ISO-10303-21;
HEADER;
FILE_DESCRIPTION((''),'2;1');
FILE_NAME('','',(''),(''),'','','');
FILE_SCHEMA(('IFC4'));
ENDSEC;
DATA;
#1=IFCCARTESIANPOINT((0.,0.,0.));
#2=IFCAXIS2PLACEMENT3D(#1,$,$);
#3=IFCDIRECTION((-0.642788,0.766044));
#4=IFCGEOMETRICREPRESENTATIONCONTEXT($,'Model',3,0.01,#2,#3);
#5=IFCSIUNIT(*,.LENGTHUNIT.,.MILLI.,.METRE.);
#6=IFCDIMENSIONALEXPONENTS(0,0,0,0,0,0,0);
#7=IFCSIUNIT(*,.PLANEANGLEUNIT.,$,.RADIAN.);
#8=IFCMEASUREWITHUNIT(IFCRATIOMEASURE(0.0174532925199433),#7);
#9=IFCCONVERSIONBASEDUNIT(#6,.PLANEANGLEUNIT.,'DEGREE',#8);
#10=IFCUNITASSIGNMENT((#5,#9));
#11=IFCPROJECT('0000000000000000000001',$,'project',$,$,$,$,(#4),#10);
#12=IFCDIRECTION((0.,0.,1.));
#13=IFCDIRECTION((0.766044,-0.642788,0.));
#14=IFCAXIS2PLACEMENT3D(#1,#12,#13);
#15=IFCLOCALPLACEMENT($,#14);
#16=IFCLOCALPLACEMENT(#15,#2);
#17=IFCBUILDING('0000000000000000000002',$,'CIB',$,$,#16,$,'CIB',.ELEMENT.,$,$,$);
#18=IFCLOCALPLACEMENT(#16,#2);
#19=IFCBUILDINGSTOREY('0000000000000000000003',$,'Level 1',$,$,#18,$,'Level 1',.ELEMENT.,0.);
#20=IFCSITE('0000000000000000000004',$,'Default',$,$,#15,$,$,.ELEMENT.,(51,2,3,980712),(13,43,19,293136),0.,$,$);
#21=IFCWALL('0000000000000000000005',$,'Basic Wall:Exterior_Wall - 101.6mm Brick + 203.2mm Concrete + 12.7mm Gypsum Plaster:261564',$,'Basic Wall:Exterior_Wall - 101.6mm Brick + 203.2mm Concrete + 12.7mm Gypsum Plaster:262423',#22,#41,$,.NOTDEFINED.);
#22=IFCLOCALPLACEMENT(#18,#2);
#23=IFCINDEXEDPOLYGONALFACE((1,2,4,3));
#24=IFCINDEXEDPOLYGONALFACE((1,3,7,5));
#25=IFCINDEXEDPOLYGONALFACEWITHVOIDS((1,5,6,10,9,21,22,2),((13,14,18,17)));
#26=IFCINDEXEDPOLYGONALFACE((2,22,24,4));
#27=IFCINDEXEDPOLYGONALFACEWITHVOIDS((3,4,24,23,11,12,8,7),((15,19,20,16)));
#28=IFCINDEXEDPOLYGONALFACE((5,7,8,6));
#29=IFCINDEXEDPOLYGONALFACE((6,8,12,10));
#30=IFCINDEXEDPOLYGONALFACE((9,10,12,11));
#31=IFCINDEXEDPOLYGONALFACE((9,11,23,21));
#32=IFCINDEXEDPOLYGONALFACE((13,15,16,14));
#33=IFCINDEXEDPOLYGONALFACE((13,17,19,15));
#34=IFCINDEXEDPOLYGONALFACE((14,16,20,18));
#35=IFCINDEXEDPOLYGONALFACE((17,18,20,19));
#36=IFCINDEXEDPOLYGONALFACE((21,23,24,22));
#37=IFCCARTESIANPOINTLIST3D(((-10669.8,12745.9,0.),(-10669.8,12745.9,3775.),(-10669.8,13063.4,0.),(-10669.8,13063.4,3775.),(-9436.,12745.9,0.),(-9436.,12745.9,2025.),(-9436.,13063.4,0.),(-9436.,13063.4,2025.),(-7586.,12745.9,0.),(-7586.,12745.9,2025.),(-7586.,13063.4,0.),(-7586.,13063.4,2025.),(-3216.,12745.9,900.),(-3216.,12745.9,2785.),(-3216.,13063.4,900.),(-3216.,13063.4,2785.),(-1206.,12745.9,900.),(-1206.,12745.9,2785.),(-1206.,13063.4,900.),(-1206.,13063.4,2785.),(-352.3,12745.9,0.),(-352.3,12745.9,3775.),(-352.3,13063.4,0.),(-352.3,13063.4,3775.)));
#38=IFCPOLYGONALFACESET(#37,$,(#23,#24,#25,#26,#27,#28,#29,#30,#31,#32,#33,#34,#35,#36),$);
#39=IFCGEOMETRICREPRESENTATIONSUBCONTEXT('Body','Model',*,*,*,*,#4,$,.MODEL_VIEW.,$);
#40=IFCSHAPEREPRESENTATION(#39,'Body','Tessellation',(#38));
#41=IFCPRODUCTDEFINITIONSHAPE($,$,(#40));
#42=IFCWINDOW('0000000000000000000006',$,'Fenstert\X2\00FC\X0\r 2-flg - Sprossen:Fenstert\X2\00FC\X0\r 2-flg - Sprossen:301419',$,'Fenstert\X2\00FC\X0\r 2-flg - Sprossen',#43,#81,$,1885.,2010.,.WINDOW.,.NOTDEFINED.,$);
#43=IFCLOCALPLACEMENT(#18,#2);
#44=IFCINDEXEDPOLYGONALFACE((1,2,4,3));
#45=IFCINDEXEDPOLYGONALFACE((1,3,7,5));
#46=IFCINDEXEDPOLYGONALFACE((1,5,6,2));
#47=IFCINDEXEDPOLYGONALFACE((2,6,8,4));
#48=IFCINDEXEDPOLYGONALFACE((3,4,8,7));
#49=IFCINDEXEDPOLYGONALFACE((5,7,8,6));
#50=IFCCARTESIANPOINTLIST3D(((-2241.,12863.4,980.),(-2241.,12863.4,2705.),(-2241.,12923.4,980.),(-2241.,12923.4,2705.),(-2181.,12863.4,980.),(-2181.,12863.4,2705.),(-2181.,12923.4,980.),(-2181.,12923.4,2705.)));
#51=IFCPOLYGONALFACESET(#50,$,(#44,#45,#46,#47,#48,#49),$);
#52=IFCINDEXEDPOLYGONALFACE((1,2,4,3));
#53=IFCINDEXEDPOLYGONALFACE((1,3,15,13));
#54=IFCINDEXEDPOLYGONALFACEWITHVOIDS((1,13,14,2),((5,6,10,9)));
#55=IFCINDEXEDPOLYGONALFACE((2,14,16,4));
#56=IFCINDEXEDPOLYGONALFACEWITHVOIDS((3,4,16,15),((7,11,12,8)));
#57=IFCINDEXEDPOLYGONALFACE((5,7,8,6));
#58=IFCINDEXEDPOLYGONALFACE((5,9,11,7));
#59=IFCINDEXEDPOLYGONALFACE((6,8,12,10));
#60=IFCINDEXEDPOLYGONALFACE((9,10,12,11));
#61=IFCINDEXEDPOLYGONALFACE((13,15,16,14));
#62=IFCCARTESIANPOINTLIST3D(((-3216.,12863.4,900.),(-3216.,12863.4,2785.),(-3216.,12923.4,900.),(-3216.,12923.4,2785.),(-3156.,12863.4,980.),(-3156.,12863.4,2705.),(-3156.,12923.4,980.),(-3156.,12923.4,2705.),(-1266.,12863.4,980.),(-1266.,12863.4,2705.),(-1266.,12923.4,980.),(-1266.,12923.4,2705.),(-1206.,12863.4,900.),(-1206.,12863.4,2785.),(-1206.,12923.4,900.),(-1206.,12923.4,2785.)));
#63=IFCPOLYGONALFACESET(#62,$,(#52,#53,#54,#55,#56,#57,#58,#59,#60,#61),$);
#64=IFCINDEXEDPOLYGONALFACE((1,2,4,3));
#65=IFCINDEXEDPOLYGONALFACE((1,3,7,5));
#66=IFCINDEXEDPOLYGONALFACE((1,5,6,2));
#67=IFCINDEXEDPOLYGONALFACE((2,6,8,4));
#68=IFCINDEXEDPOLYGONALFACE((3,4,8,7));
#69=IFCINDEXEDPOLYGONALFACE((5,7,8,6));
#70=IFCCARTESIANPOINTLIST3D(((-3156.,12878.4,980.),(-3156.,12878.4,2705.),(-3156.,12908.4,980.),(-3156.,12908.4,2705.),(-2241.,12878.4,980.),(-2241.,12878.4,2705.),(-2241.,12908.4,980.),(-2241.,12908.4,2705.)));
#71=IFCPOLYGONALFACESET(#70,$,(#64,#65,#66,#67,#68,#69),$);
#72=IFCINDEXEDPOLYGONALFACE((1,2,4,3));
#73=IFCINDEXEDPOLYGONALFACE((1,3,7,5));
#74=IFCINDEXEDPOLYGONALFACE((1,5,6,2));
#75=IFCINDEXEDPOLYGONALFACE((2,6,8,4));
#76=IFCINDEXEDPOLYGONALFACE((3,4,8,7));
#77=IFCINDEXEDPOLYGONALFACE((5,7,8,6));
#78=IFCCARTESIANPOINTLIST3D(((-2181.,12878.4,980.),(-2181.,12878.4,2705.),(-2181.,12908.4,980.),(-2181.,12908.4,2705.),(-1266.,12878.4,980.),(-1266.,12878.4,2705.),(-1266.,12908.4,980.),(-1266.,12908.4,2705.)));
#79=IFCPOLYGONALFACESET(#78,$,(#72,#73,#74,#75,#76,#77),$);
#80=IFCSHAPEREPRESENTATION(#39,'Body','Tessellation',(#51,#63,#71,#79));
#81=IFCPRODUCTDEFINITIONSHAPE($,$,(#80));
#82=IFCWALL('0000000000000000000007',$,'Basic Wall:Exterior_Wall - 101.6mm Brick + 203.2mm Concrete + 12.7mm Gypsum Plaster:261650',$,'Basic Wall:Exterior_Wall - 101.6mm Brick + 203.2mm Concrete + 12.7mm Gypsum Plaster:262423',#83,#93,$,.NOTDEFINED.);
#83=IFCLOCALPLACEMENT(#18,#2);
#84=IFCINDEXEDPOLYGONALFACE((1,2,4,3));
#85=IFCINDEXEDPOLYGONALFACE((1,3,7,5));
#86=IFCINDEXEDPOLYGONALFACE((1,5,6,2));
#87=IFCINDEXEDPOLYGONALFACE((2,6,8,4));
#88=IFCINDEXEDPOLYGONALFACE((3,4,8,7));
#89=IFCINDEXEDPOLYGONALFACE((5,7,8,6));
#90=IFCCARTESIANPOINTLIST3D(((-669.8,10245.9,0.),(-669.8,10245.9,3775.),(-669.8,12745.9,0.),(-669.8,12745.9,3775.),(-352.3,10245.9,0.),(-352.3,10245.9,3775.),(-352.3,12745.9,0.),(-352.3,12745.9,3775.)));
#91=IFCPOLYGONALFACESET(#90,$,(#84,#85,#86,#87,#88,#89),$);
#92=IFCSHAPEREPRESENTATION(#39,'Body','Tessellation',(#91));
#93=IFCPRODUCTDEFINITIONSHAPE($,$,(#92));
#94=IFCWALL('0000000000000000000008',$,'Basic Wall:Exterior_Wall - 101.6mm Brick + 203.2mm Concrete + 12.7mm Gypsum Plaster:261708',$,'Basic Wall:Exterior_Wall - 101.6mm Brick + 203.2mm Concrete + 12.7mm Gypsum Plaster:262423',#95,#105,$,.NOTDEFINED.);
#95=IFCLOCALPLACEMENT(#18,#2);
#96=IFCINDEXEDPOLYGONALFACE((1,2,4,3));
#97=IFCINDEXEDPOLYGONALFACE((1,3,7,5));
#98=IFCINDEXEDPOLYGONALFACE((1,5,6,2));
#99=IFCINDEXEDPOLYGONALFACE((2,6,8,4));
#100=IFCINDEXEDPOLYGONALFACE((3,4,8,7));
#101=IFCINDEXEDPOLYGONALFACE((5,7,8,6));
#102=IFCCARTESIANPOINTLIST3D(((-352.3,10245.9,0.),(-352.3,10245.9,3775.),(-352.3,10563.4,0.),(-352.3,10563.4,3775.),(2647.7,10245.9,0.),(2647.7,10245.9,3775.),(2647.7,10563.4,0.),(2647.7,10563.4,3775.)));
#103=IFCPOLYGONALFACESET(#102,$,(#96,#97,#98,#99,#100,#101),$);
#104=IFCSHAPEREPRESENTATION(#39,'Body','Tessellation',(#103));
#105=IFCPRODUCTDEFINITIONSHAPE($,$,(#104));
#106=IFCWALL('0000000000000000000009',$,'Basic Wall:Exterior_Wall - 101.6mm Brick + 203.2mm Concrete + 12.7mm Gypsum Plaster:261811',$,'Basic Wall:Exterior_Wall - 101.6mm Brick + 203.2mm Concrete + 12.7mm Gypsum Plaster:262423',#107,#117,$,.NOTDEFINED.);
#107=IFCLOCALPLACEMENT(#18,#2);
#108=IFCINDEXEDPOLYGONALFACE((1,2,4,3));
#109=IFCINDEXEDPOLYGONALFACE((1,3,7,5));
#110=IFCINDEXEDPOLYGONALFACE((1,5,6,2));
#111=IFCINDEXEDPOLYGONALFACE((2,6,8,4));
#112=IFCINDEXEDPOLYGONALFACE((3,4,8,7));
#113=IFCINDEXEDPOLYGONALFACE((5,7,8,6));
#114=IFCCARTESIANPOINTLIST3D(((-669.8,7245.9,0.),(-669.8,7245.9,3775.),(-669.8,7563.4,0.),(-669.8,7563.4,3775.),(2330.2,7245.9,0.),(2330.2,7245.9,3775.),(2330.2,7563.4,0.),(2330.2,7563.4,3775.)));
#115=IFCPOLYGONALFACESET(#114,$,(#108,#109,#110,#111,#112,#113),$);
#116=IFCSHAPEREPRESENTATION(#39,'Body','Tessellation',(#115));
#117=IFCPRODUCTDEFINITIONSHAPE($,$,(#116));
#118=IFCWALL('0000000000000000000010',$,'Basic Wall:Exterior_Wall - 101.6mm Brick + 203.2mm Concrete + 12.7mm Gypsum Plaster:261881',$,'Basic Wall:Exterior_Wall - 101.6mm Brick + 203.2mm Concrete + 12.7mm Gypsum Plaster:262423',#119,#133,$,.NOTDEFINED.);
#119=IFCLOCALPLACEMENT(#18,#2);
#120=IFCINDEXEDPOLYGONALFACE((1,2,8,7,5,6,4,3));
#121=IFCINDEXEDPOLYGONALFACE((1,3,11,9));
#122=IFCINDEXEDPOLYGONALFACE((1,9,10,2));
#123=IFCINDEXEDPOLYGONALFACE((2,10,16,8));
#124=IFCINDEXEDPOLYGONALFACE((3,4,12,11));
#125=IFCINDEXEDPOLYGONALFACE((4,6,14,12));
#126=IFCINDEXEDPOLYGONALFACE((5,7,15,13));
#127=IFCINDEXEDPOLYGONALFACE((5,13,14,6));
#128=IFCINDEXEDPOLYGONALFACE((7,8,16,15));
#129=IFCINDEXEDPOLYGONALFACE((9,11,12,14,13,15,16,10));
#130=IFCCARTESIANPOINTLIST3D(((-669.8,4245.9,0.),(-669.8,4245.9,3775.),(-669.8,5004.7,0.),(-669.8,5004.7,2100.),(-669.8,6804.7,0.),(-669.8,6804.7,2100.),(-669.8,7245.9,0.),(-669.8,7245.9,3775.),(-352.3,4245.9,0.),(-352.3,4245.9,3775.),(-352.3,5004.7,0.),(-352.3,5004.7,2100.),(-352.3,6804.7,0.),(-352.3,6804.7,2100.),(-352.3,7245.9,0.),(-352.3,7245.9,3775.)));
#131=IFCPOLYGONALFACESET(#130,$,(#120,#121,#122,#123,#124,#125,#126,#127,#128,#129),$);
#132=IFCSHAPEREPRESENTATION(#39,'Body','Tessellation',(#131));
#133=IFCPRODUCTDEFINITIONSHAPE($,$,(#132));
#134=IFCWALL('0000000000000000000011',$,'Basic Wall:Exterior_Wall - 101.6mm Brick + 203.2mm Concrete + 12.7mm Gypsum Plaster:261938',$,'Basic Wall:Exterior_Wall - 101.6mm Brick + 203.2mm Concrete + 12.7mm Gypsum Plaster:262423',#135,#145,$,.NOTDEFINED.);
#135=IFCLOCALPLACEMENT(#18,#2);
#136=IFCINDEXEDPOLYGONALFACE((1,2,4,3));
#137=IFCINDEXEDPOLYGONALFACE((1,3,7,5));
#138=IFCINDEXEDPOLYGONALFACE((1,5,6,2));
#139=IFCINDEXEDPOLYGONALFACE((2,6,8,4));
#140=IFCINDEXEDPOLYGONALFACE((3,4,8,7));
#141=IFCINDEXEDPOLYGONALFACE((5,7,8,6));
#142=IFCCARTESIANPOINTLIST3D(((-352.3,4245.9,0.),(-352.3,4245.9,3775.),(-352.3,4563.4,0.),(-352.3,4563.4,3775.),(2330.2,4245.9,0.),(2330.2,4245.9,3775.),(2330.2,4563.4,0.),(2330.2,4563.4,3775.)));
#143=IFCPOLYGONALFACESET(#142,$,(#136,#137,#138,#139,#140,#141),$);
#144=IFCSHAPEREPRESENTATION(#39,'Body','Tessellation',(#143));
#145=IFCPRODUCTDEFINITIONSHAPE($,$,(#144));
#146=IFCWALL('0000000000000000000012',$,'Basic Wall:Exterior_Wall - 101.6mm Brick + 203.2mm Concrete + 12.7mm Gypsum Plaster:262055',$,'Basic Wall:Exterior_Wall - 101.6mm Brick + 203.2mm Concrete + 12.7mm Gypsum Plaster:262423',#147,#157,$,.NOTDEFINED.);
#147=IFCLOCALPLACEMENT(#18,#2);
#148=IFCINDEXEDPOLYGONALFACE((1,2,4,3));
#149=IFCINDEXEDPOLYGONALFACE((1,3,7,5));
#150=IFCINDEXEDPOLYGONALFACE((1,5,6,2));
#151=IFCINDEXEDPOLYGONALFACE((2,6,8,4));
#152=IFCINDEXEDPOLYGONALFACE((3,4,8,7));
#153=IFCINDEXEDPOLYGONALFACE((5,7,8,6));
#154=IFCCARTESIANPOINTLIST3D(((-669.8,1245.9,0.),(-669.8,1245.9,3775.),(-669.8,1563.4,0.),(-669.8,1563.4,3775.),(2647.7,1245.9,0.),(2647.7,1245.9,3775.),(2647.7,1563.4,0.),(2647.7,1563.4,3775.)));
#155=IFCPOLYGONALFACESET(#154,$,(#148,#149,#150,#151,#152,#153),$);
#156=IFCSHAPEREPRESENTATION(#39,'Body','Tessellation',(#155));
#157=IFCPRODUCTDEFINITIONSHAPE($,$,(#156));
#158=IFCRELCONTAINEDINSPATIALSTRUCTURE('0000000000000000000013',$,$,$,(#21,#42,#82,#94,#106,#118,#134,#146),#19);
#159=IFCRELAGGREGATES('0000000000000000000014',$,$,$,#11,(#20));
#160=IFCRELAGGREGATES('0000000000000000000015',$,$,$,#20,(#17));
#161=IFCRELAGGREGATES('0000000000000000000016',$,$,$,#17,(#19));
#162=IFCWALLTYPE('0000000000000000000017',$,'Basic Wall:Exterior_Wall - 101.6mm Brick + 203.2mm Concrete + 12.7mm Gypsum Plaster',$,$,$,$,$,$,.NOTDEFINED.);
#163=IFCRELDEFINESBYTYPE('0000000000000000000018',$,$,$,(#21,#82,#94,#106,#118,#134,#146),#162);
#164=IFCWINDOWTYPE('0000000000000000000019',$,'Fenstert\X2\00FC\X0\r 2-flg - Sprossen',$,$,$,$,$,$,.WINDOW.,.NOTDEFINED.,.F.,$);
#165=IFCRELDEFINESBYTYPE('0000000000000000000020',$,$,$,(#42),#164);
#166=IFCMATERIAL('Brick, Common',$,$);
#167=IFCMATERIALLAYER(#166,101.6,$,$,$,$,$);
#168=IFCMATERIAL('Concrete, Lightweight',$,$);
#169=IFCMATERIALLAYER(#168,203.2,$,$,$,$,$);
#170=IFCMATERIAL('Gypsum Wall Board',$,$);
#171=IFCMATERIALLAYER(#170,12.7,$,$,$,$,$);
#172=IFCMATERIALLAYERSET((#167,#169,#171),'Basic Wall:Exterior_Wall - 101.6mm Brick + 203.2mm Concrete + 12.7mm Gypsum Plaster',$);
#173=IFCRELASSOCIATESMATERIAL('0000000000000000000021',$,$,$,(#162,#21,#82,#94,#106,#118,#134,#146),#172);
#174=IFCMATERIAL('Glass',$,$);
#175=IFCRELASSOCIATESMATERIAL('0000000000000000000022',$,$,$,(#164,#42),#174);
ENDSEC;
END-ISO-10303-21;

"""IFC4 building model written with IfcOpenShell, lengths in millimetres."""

from ifc_helpers import new_model, entity, si_unit, converted_unit, direction, frame, frame_2d, origin, origin_2d_with_axis, place, context, subcontext, project, spatial, polyline, rectangle, outline, extrude, clip, bounded_halfspace, source, transform, mapped, material, layer, layer_set, layer_usage, type_object, type_shapes, element, fill, save


model = new_model("IFC4")

# Units and contexts
model_context = context("Model", 3, precision=0.01, world=origin(), true_north=direction((-0.642788, 0.766044)))
body_context = subcontext(model_context, "Body", "Model", "MODEL_VIEW")
ifc_project = project(units=[si_unit("LENGTHUNIT", "METRE", prefix="MILLI"), converted_unit("PLANEANGLEUNIT", "DEGREE", entity("IfcRatioMeasure", 0.0174532925199433), si_unit("PLANEANGLEUNIT", "RADIAN"), dimensions=[0, 0, 0, 0, 0, 0, 0])], contexts=[model_context])

# Site, building, storey
site_placement = place(None, frame((0.0, 0.0, 0.0), z_axis=(0.0, 0.0, 1.0), x_axis=(0.766044, -0.642788, 0.0)))
site = spatial("IfcSite", under=ifc_project, at=site_placement, Name="Default", CompositionType="ELEMENT", RefLatitude=(51, 2, 3, 980712), RefLongitude=(13, 43, 19, 293136), RefElevation=0.0)
building_placement = place(site_placement, origin())
building = spatial("IfcBuilding", under=site, at=building_placement, Name="CIB", LongName="CIB", CompositionType="ELEMENT")
storey_placement = place(building_placement, origin())
storey = spatial("IfcBuildingStorey", under=building, at=storey_placement, Name="Level 1", LongName="Level 1", CompositionType="ELEMENT", Elevation=0.0)

# Wall, openings, window
ifc_material_1 = material(Name="Brick, Common")
ifc_layer_1 = layer(ifc_material_1, 101.6)
ifc_material_2 = material(Name="Concrete, Lightweight")
ifc_layer_2 = layer(ifc_material_2, 203.2)
ifc_material_3 = material(Name="Gypsum Wall Board")
ifc_layer_3 = layer(ifc_material_3, 12.7)
ifc_layer_set_1 = layer_set([ifc_layer_1, ifc_layer_2, ifc_layer_3], Name="Basic Wall:Exterior_Wall - 101.6mm Brick + 203.2mm Concrete + 12.7mm Gypsum Plaster")
ifc_layer_usage_1 = layer_usage(ifc_layer_set_1, "AXIS2", "NEGATIVE", 158.8)
wall_type_1 = type_object("IfcWallType", Name="Basic Wall:Exterior_Wall - 101.6mm Brick + 203.2mm Concrete + 12.7mm Gypsum Plaster", PredefinedType="NOTDEFINED", material=ifc_layer_set_1)
wall_1_placement = place(storey_placement, frame((-10669.8, 12904.7, 0.0)))
wall_1 = element("IfcWall", 1, at=wall_1_placement, inside=storey, type_object=wall_type_1, material=ifc_layer_usage_1, Name="Basic Wall:Exterior_Wall - 101.6mm Brick + 203.2mm Concrete + 12.7mm Gypsum Plaster:261564", ObjectType="Basic Wall:Exterior_Wall - 101.6mm Brick + 203.2mm Concrete + 12.7mm Gypsum Plaster:262423", PredefinedType="NOTDEFINED", context=body_context, shape_type="Clipping", body=[
    clip(extrude(rectangle(XDim=10317.5, YDim=317.5, at=frame_2d((5158.7, 0.0), x_axis=(-1.0, 0.0))), origin(), (0.0, 0.0, 1.0), 3775.0), bounded_halfspace(frame((0.0, -158.7, 3775.0), z_axis=(0.0, 0.0, -1.0), x_axis=(1.0, 0.0, 0.0)), True, frame((0.0, -158.7, 3775.0)), polyline([(0.0, 0.0), (317.5, 0.0), (10000.0, 0.0), (10317.5, 0.0), (10317.5, 317.5), (0.0, 317.5), (0.0, 0.0)]))),
])
opening_1_placement = place(wall_1_placement, frame((3083.8, 158.7, 0.0)))
element("IfcOpeningElement", 2, at=opening_1_placement, cuts=wall_1, ObjectType="Opening", PredefinedType="OPENING", context=body_context, shape_type="SweptSolid", body=[
    extrude(rectangle(XDim=2025.0, YDim=1850.0, at=frame_2d((1012.5, 925.0), x_axis=(1.0, 0.0))), frame((0.0, 0.0, 0.0), z_axis=(0.0, -1.0, 0.0), x_axis=(0.0, 0.0, 1.0)), (0.0, 0.0, 1.0), 317.5),
])
opening_2_placement = place(wall_1_placement, frame((9463.7, 158.7, 900.0)))
opening_2 = element("IfcOpeningElement", 3, at=opening_2_placement, cuts=wall_1, ObjectType="Opening", PredefinedType="OPENING", context=body_context, shape_type="SweptSolid", body=[
    extrude(rectangle(XDim=1885.0, YDim=2010.0, at=frame_2d((942.5, 1005.0), x_axis=(1.0, 0.0))), frame((0.0, 0.0, 0.0), z_axis=(0.0, -1.0, 0.0), x_axis=(0.0, 0.0, 1.0)), (0.0, 0.0, 1.0), 317.5),
])
ifc_material_4 = material(Name="Glass")
window_type_1 = type_object("IfcWindowType", Name="Fenstertür 2-flg - Sprossen", ParameterTakesPrecedence=False, PartitioningType="NOTDEFINED", PredefinedType="WINDOW", material=ifc_material_4)
shared_shape_1 = source(origin(), body_context, "Body", "SweptSolid", [
    extrude(rectangle(XDim=60.0, YDim=60.0, at=origin_2d_with_axis()), frame((1005.0, 147.5, 80.0), z_axis=(0.0, 0.0, 1.0), x_axis=(0.0, 1.0, 0.0)), (0.0, 0.0, 1.0), 1725.0),
    extrude(outline(polyline([(-1005.0, -942.5), (1005.0, -942.5), (1005.0, 942.5), (-1005.0, 942.5), (-1005.0, -942.5)]), holes=[polyline([(-945.0, -862.5), (-945.0, 862.5), (945.0, 862.5), (945.0, -862.5), (-945.0, -862.5)])]), frame((1005.0, 117.5, 942.5), z_axis=(0.0, 1.0, 0.0), x_axis=(1.0, 0.0, 0.0)), (0.0, 0.0, 1.0), 60.0),
    extrude(rectangle(XDim=30.0, YDim=915.0, at=frame_2d((0.0, 0.0), x_axis=(1.0, 0.0))), frame((517.5, 147.5, 80.0), z_axis=(0.0, 0.0, 1.0), x_axis=(0.0, -1.0, 0.0)), (0.0, 0.0, 1.0), 1725.0),
    extrude(rectangle(XDim=30.0, YDim=915.0, at=frame_2d((0.0, 0.0), x_axis=(1.0, 0.0))), frame((1492.5, 147.5, 80.0), z_axis=(0.0, 0.0, 1.0), x_axis=(0.0, -1.0, 0.0)), (0.0, 0.0, 1.0), 1725.0),
])
type_shapes(window_type_1, [shared_shape_1])
window_1_placement = place(opening_2_placement, frame((-2010.0, -317.5, 0.0)))
window_1 = element("IfcWindow", 4, at=window_1_placement, inside=storey, type_object=window_type_1, material=ifc_material_4, Name="Fenstertür 2-flg - Sprossen:Fenstertür 2-flg - Sprossen:301419", ObjectType="Fenstertür 2-flg - Sprossen", OverallHeight=1885.0, OverallWidth=2010.0, PartitioningType="NOTDEFINED", PredefinedType="WINDOW", context=body_context, shape_type="MappedRepresentation", body=[
    mapped(shared_shape_1, transform((0.0, 0.0, 0.0), scale=1.0)),
])
fill(opening_2, window_1)

# Walls
ifc_layer_usage_2 = layer_usage(ifc_layer_set_1, "AXIS2", "NEGATIVE", 158.8)
wall_2_placement = place(storey_placement, frame((-511.0, 12745.9, 0.0), z_axis=(0.0, 0.0, 1.0), x_axis=(0.0, -1.0, 0.0)))
element("IfcWall", 5, at=wall_2_placement, inside=storey, type_object=wall_type_1, material=ifc_layer_usage_2, Name="Basic Wall:Exterior_Wall - 101.6mm Brick + 203.2mm Concrete + 12.7mm Gypsum Plaster:261650", ObjectType="Basic Wall:Exterior_Wall - 101.6mm Brick + 203.2mm Concrete + 12.7mm Gypsum Plaster:262423", PredefinedType="NOTDEFINED", context=body_context, shape_type="Clipping", body=[
    clip(extrude(rectangle(XDim=2500.0, YDim=317.5, at=frame_2d((1250.0, 0.0), x_axis=(-1.0, 0.0))), origin(), (0.0, 0.0, 1.0), 3775.0), bounded_halfspace(frame((0.0, -158.8, 3775.0), z_axis=(0.0, 0.0, -1.0), x_axis=(0.0, 1.0, 0.0)), True, frame((0.0, -158.8, 3775.0)), polyline([(0.0, 0.0), (2500.0, 0.0), (2500.0, 317.5), (2182.5, 317.5), (0.0, 317.5), (0.0, 0.0)]))),
])
ifc_layer_usage_3 = layer_usage(ifc_layer_set_1, "AXIS2", "NEGATIVE", 158.8)
wall_3_placement = place(storey_placement, frame((-352.3, 10404.7, 0.0)))
element("IfcWall", 6, at=wall_3_placement, inside=storey, type_object=wall_type_1, material=ifc_layer_usage_3, Name="Basic Wall:Exterior_Wall - 101.6mm Brick + 203.2mm Concrete + 12.7mm Gypsum Plaster:261708", ObjectType="Basic Wall:Exterior_Wall - 101.6mm Brick + 203.2mm Concrete + 12.7mm Gypsum Plaster:262423", PredefinedType="NOTDEFINED", context=body_context, shape_type="Clipping", body=[
    clip(extrude(rectangle(XDim=3000.0, YDim=317.5, at=frame_2d((1500.0, 0.0), x_axis=(-1.0, 0.0))), origin(), (0.0, 0.0, 1.0), 3775.0), bounded_halfspace(frame((0.0, -158.7, 3775.0), z_axis=(0.0, 0.0, -1.0), x_axis=(1.0, 0.0, 0.0)), True, frame((0.0, -158.7, 3775.0)), polyline([(0.0, 0.0), (2682.5, 0.0), (3000.0, 0.0), (3000.0, 317.5), (0.0, 317.5), (0.0, 0.0)]))),
])
ifc_layer_usage_4 = layer_usage(ifc_layer_set_1, "AXIS2", "NEGATIVE", 158.8)
wall_4_placement = place(storey_placement, frame((2330.2, 7404.7, 0.0), z_axis=(0.0, 0.0, 1.0), x_axis=(-1.0, 0.0, 0.0)))
element("IfcWall", 7, at=wall_4_placement, inside=storey, type_object=wall_type_1, material=ifc_layer_usage_4, Name="Basic Wall:Exterior_Wall - 101.6mm Brick + 203.2mm Concrete + 12.7mm Gypsum Plaster:261811", ObjectType="Basic Wall:Exterior_Wall - 101.6mm Brick + 203.2mm Concrete + 12.7mm Gypsum Plaster:262423", PredefinedType="NOTDEFINED", context=body_context, shape_type="Clipping", body=[
    clip(extrude(rectangle(XDim=3000.0, YDim=317.5, at=frame_2d((1500.0, 0.0), x_axis=(-1.0, 0.0))), origin(), (0.0, 0.0, 1.0), 3775.0), bounded_halfspace(frame((0.0, -158.8, 3775.0), z_axis=(0.0, 0.0, -1.0), x_axis=(-1.0, 0.0, 0.0)), True, frame((0.0, -158.8, 3775.0)), polyline([(0.0, 0.0), (3000.0, 0.0), (3000.0, 317.5), (2682.5, 317.5), (0.0, 317.5), (0.0, 0.0)]))),
])

# Wall, opening
ifc_layer_usage_5 = layer_usage(ifc_layer_set_1, "AXIS2", "NEGATIVE", 158.8)
wall_5_placement = place(storey_placement, frame((-511.0, 7245.9, 0.0), z_axis=(0.0, 0.0, 1.0), x_axis=(0.0, -1.0, 0.0)))
wall_5 = element("IfcWall", 8, at=wall_5_placement, inside=storey, type_object=wall_type_1, material=ifc_layer_usage_5, Name="Basic Wall:Exterior_Wall - 101.6mm Brick + 203.2mm Concrete + 12.7mm Gypsum Plaster:261881", ObjectType="Basic Wall:Exterior_Wall - 101.6mm Brick + 203.2mm Concrete + 12.7mm Gypsum Plaster:262423", PredefinedType="NOTDEFINED", context=body_context, shape_type="Clipping", body=[
    clip(extrude(rectangle(XDim=3000.0, YDim=317.5, at=frame_2d((1500.0, 0.0), x_axis=(-1.0, 0.0))), origin(), (0.0, 0.0, 1.0), 3775.0), bounded_halfspace(frame((0.0, 158.8, 3775.0), z_axis=(0.0, 0.0, -1.0), x_axis=(0.0, 1.0, 0.0)), True, frame((0.0, 158.8, 3775.0)), polyline([(0.0, 0.0), (0.0, -317.5), (3000.0, -317.5), (3000.0, 0.0), (2682.5, 0.0), (0.0, 0.0)]))),
])
opening_3_placement = place(wall_5_placement, frame((2241.3, 158.8, 0.0)))
element("IfcOpeningElement", 9, at=opening_3_placement, cuts=wall_5, ObjectType="Opening", PredefinedType="OPENING", context=body_context, shape_type="SweptSolid", body=[
    extrude(rectangle(XDim=2100.0, YDim=1800.0, at=frame_2d((1050.0, 900.0), x_axis=(1.0, 0.0))), frame((0.0, 0.0, 0.0), z_axis=(0.0, -1.0, 0.0), x_axis=(0.0, 0.0, 1.0)), (0.0, 0.0, 1.0), 317.5),
])

# Walls
ifc_layer_usage_6 = layer_usage(ifc_layer_set_1, "AXIS2", "NEGATIVE", 158.8)
wall_6_placement = place(storey_placement, frame((-352.3, 4404.7, 0.0)))
element("IfcWall", 10, at=wall_6_placement, inside=storey, type_object=wall_type_1, material=ifc_layer_usage_6, Name="Basic Wall:Exterior_Wall - 101.6mm Brick + 203.2mm Concrete + 12.7mm Gypsum Plaster:261938", ObjectType="Basic Wall:Exterior_Wall - 101.6mm Brick + 203.2mm Concrete + 12.7mm Gypsum Plaster:262423", PredefinedType="NOTDEFINED", context=body_context, shape_type="Clipping", body=[
    clip(extrude(rectangle(XDim=2682.5, YDim=317.5, at=frame_2d((1341.2, 0.0), x_axis=(-1.0, 0.0))), origin(), (0.0, 0.0, 1.0), 3775.0), bounded_halfspace(frame((0.0, -158.8, 3775.0), z_axis=(0.0, 0.0, -1.0), x_axis=(1.0, 0.0, 0.0)), True, frame((0.0, -158.8, 3775.0)), polyline([(0.0, 0.0), (2682.5, 0.0), (2682.5, 317.5), (0.0, 317.5), (0.0, 0.0)]))),
])
ifc_layer_usage_7 = layer_usage(ifc_layer_set_1, "AXIS2", "NEGATIVE", 158.8)
wall_7_placement = place(storey_placement, frame((2647.7, 1404.7, 0.0), z_axis=(0.0, 0.0, 1.0), x_axis=(-1.0, 0.0, 0.0)))
element("IfcWall", 11, at=wall_7_placement, inside=storey, type_object=wall_type_1, material=ifc_layer_usage_7, Name="Basic Wall:Exterior_Wall - 101.6mm Brick + 203.2mm Concrete + 12.7mm Gypsum Plaster:262055", ObjectType="Basic Wall:Exterior_Wall - 101.6mm Brick + 203.2mm Concrete + 12.7mm Gypsum Plaster:262423", PredefinedType="NOTDEFINED", context=body_context, shape_type="Clipping", body=[
    clip(extrude(rectangle(XDim=3317.5, YDim=317.5, at=frame_2d((1658.7, 0.0), x_axis=(-1.0, 0.0))), origin(), (0.0, 0.0, 1.0), 3775.0), bounded_halfspace(frame((0.0, -158.8, 3775.0), z_axis=(0.0, 0.0, -1.0), x_axis=(-1.0, 0.0, 0.0)), True, frame((0.0, -158.8, 3775.0)), polyline([(0.0, 0.0), (317.5, 0.0), (3317.5, 0.0), (3317.5, 317.5), (3000.0, 317.5), (0.0, 317.5), (0.0, 0.0)]))),
])

save(model, "model.ifc")
